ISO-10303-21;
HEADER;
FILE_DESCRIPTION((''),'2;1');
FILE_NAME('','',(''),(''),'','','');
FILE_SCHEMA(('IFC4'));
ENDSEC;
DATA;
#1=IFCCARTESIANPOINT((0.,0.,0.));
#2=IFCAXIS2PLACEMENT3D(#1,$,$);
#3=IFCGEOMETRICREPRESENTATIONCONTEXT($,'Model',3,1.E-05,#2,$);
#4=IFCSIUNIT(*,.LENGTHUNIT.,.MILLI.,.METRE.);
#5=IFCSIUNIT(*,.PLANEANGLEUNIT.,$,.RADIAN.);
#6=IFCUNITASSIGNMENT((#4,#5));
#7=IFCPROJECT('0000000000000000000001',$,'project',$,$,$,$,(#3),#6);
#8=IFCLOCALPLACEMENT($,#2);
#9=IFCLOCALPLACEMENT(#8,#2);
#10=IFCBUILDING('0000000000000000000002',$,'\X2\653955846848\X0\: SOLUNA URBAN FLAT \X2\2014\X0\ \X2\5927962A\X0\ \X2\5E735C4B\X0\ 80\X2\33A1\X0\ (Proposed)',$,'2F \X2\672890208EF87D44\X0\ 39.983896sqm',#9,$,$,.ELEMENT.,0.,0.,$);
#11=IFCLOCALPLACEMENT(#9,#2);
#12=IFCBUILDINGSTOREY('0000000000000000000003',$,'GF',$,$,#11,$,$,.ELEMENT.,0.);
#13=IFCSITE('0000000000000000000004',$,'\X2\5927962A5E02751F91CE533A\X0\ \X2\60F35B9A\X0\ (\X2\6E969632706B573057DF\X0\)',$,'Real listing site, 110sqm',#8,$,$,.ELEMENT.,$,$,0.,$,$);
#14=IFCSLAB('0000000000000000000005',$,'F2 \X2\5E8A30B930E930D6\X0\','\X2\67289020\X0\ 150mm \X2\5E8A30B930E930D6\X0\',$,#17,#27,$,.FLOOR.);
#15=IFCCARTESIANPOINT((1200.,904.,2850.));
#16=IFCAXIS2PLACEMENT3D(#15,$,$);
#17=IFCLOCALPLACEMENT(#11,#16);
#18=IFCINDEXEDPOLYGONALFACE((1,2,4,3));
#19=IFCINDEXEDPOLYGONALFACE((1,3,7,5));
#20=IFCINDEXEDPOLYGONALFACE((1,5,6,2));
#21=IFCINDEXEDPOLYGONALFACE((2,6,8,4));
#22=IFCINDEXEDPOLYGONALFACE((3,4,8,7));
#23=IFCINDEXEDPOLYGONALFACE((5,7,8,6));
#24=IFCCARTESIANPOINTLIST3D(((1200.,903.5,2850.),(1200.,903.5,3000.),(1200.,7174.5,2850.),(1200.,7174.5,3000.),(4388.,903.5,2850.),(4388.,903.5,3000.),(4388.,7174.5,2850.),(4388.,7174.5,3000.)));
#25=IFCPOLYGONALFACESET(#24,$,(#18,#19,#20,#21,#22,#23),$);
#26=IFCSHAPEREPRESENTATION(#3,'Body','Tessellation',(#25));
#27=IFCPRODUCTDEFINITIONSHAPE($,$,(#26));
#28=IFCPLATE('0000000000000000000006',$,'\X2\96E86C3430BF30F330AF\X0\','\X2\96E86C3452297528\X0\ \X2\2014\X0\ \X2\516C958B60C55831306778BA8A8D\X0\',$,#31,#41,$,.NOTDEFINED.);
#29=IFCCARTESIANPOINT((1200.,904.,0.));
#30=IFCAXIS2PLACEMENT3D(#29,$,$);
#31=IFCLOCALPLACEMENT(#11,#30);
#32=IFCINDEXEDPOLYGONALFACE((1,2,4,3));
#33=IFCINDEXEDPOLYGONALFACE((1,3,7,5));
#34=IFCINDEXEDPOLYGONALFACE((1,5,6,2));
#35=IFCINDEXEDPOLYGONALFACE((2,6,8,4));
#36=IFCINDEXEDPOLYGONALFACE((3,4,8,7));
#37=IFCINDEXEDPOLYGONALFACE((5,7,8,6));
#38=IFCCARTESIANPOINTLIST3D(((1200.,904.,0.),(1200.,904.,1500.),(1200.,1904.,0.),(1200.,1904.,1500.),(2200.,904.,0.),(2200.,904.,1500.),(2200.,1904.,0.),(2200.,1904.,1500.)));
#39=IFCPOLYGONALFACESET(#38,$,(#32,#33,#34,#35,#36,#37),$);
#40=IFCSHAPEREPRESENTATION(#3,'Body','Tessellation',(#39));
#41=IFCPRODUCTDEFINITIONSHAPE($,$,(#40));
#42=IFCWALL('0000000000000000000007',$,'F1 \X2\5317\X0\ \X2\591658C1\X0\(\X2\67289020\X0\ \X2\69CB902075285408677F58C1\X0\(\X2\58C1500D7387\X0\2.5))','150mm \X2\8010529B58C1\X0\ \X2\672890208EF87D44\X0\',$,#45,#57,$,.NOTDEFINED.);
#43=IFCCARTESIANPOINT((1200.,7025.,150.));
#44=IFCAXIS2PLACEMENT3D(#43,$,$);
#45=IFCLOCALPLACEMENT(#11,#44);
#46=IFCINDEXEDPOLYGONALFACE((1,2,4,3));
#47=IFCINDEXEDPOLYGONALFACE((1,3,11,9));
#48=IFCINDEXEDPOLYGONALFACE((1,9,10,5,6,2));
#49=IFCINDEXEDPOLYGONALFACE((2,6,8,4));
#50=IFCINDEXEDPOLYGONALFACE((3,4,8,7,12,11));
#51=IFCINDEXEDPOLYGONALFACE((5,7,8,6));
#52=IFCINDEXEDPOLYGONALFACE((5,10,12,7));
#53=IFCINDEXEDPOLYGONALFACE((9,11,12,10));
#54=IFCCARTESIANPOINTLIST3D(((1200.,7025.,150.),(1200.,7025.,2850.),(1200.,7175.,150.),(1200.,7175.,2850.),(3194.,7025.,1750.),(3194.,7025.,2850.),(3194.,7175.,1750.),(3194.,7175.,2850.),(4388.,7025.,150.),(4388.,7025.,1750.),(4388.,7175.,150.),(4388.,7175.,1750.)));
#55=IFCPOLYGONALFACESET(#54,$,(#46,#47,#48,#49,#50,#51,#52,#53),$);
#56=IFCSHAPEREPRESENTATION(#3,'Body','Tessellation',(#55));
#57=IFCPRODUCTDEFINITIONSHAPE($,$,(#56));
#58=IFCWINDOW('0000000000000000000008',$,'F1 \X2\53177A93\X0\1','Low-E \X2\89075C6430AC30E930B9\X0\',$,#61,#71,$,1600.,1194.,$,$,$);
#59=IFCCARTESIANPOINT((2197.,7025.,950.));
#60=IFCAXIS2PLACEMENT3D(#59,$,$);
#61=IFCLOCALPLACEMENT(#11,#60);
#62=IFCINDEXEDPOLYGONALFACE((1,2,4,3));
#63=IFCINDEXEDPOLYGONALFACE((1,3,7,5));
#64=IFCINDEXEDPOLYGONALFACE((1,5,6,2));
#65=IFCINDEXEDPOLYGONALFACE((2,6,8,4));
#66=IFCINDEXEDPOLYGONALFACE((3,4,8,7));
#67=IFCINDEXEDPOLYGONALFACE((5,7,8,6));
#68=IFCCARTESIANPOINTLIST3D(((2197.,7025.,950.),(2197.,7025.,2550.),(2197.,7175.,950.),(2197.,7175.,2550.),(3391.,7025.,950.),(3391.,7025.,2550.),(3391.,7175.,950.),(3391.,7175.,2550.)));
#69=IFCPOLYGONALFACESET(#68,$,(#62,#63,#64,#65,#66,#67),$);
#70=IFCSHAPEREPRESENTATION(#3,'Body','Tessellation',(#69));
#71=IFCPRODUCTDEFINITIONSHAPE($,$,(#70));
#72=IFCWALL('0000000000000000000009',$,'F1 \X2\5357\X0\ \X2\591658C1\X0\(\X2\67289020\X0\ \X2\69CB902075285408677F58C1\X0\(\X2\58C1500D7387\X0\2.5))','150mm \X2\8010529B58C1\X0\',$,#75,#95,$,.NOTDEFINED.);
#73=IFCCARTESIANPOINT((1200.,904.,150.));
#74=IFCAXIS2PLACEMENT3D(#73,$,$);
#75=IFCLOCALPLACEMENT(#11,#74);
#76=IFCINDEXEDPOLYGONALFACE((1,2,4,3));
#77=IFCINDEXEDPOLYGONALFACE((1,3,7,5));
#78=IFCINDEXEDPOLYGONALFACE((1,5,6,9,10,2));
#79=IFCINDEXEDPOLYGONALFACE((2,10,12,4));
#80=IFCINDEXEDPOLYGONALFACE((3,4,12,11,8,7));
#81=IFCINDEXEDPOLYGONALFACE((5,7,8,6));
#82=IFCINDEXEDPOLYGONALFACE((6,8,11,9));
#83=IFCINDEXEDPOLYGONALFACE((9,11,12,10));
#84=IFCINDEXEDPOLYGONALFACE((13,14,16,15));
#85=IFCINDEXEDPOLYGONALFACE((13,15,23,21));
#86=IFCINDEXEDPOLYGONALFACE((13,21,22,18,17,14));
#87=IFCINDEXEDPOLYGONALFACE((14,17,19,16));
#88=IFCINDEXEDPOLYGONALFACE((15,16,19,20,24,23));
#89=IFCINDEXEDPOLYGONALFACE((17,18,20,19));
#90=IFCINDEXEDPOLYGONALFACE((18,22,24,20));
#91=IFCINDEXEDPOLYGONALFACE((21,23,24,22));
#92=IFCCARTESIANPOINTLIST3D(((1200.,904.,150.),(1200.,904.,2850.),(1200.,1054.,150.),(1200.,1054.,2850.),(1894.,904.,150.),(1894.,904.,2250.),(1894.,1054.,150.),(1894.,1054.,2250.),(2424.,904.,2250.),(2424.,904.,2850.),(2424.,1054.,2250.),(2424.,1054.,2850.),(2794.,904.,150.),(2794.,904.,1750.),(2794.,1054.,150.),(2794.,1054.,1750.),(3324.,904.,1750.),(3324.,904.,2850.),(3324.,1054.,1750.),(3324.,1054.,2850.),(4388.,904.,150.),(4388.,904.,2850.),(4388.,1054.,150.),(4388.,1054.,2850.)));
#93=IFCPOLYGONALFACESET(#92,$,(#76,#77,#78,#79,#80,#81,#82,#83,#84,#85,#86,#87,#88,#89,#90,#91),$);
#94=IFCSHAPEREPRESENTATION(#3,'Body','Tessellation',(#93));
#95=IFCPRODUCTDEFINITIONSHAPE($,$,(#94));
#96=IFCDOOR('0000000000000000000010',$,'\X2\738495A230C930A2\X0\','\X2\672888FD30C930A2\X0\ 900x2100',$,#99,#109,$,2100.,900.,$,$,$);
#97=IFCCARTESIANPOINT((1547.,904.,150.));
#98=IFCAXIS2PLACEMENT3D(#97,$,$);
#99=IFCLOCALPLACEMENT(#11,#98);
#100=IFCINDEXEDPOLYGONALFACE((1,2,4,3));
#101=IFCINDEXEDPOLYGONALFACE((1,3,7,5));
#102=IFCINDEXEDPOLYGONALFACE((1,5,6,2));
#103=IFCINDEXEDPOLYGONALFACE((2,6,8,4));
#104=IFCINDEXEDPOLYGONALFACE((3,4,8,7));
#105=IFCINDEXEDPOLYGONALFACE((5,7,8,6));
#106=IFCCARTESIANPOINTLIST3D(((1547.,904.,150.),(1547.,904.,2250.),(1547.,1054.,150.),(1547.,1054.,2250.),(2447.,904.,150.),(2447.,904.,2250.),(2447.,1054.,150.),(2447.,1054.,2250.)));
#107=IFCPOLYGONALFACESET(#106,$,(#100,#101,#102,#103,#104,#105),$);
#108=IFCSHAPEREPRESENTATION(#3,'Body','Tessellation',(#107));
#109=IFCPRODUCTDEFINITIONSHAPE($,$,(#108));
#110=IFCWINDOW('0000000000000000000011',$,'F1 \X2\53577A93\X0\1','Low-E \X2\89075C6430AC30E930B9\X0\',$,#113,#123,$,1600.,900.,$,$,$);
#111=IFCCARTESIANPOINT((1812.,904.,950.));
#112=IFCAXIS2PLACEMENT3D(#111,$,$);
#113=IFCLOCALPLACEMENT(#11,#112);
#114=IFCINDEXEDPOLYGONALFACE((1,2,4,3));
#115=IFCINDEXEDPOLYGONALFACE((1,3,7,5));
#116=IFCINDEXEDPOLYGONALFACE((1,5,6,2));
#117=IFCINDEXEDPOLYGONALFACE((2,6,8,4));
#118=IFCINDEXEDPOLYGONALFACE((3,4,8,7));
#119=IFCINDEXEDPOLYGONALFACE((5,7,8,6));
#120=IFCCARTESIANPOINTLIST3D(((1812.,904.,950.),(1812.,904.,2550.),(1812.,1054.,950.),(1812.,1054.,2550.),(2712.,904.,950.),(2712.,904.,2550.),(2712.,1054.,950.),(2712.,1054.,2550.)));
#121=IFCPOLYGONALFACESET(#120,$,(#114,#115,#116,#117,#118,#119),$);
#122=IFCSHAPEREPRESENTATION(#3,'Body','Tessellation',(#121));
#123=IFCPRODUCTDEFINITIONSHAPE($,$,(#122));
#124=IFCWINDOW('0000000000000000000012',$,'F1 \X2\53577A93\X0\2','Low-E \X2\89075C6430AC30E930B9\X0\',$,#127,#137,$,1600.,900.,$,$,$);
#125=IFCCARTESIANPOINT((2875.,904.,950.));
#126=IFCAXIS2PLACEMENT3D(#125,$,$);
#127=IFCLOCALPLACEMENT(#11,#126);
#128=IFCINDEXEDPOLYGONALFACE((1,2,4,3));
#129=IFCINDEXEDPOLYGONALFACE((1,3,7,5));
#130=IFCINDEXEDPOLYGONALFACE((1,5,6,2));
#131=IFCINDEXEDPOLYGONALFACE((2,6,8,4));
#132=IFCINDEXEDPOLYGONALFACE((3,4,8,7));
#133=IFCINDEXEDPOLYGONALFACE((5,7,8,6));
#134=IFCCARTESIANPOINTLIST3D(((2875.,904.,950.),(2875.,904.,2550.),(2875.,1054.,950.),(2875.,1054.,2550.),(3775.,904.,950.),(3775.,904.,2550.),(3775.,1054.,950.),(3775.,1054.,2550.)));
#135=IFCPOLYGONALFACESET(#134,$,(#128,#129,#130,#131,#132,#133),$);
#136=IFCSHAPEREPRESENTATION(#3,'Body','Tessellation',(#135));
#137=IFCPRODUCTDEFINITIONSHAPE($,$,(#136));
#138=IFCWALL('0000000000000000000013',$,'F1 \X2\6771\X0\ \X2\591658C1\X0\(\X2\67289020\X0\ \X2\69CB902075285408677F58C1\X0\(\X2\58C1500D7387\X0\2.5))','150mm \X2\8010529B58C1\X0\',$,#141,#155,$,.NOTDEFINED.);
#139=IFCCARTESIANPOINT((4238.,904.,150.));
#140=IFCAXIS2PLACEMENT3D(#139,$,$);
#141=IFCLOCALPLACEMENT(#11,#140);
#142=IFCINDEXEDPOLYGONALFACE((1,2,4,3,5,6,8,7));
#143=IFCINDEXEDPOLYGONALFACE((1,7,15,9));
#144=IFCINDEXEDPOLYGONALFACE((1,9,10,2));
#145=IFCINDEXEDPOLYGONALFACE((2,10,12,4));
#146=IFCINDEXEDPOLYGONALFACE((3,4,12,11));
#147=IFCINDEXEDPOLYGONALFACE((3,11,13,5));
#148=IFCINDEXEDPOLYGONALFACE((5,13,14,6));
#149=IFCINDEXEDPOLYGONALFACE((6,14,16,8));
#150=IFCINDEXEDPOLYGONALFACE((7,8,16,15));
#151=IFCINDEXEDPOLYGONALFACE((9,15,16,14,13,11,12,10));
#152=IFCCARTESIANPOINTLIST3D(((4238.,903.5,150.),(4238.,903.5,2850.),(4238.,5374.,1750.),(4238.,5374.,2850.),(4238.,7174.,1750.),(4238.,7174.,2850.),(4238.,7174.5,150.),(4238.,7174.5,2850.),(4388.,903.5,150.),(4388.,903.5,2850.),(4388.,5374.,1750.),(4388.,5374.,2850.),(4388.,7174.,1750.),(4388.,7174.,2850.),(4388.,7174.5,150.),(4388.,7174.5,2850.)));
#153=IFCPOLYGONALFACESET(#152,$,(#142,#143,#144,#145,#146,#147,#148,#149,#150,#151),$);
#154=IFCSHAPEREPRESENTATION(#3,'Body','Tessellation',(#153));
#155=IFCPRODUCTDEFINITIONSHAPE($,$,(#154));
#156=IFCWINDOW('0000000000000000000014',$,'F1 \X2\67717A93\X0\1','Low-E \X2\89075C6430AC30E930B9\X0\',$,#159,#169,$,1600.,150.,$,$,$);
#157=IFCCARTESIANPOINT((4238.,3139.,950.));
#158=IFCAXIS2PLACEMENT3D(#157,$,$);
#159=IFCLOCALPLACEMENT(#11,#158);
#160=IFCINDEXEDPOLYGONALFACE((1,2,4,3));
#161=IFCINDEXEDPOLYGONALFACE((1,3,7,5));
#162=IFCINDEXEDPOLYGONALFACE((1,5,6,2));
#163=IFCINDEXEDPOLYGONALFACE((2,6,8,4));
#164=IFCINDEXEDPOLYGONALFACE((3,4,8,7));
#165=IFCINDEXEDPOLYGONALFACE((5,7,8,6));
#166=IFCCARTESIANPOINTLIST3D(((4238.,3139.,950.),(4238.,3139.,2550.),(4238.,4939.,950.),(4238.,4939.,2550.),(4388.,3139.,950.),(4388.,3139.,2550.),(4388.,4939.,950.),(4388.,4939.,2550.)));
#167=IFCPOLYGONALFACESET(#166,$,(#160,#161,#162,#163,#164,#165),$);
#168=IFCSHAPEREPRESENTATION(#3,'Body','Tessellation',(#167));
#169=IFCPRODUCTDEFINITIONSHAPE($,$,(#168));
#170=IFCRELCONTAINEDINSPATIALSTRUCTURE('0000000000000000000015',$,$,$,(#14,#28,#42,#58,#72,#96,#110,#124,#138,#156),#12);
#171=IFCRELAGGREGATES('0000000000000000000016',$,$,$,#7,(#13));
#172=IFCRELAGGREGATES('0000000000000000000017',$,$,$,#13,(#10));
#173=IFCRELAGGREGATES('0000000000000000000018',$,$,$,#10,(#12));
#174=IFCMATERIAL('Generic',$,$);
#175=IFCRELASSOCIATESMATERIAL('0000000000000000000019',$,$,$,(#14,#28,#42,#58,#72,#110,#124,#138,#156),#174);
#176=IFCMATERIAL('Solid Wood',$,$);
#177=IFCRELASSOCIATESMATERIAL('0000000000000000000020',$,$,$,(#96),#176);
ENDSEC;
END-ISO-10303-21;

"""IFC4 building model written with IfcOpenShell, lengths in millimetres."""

from ifc_helpers import new_model, si_unit, frame, frame_2d, origin, place, context, project, spatial, rectangle, extrude, material, element, fill, save


model = new_model("IFC4")

# Units and contexts
model_context = context("Model", 3, precision=1e-05, world=origin())
ifc_project = project(units=[si_unit("LENGTHUNIT", "METRE", prefix="MILLI"), si_unit("PLANEANGLEUNIT", "RADIAN")], contexts=[model_context])

# Site, building, storey
site_placement = place(None, origin())
site = spatial("IfcSite", under=ifc_project, at=site_placement, Name="大阪市生野区 想定 (準防火地域)", ObjectType="Real listing site, 110sqm", CompositionType="ELEMENT", RefElevation=0.0)
building_placement = place(site_placement, origin())
building = spatial("IfcBuilding", under=site, at=building_placement, Name="改善案: SOLUNA URBAN FLAT — 大阪 平屋 80㎡ (Proposed)", ObjectType="2F 木造軸組 39.983896sqm", CompositionType="ELEMENT", ElevationOfRefHeight=0.0, ElevationOfTerrain=0.0)
storey_placement = place(building_placement, origin())
storey = spatial("IfcBuildingStorey", under=building, at=storey_placement, Name="GF", CompositionType="ELEMENT", Elevation=0.0)

# Slab
ifc_material_1 = material(Name="Generic")
slab_1_placement = place(storey_placement, frame((1200.0, 904.0, 2850.0)))
element("IfcSlab", 1, at=slab_1_placement, inside=storey, material=ifc_material_1, Name="F2 床スラブ", Description="木造 150mm 床スラブ", PredefinedType="FLOOR", context=model_context, shape_type="SweptSolid", body=[
    extrude(rectangle(XDim=3188.0, YDim=6271.0, at=frame_2d((1594.0, 3135.0))), frame((1200.0, 904.0, 2850.0)), (0.0, 0.0, 1.0), 150.0),
])

# Plate
plate_placement = place(storey_placement, frame((1200.0, 904.0, 0.0)))
element("IfcPlate", 2, at=plate_placement, inside=storey, material=ifc_material_1, Name="雨水タンク", Description="雨水利用 — 公開情報で確認", PredefinedType="NOTDEFINED", context=model_context, shape_type="SweptSolid", body=[
    extrude(rectangle(XDim=1000.0, YDim=1000.0, at=frame_2d((500.0, 500.0))), frame((1200.0, 904.0, 0.0)), (0.0, 0.0, 1.0), 1500.0),
])

# Wall, opening, window
wall_1_placement = place(storey_placement, frame((1200.0, 7025.0, 150.0)))
wall_1 = element("IfcWall", 3, at=wall_1_placement, inside=storey, material=ifc_material_1, Name="F1 北 外壁(木造 構造用合板壁(壁倍率2.5))", Description="150mm 耐力壁 木造軸組", PredefinedType="NOTDEFINED", context=model_context, shape_type="SweptSolid", body=[
    extrude(rectangle(XDim=3188.0, YDim=150.0, at=frame_2d((1594.0, 75.0))), frame((1200.0, 7025.0, 150.0)), (0.0, 0.0, 1.0), 2700.0),
])
opening_1_placement = place(storey_placement, frame((2197.0, 7025.0, 950.0)))
opening_1 = element("IfcOpeningElement", 4, at=opening_1_placement, cuts=wall_1, PredefinedType="NOTDEFINED", context=model_context, shape_type="SweptSolid", body=[
    extrude(rectangle(XDim=1194.0, YDim=150.0, at=frame_2d((597.0, 75.0))), frame((2197.0, 7025.0, 950.0)), (0.0, 0.0, 1.0), 1600.0),
])
window_1_placement = place(storey_placement, frame((2197.0, 7025.0, 950.0)))
window_1 = element("IfcWindow", 5, at=window_1_placement, inside=storey, material=ifc_material_1, Name="F1 北窓1", Description="Low-E 複層ガラス", OverallHeight=1600.0, OverallWidth=1194.0, context=model_context, shape_type="SweptSolid", body=[
    extrude(rectangle(XDim=1194.0, YDim=150.0, at=frame_2d((597.0, 75.0))), frame((2197.0, 7025.0, 950.0)), (0.0, 0.0, 1.0), 1600.0),
])
fill(opening_1, window_1)

# Wall, openings, door, windows
wall_2_placement = place(storey_placement, frame((1200.0, 904.0, 150.0)))
wall_2 = element("IfcWall", 6, at=wall_2_placement, inside=storey, material=ifc_material_1, Name="F1 南 外壁(木造 構造用合板壁(壁倍率2.5))", Description="150mm 耐力壁", PredefinedType="NOTDEFINED", context=model_context, shape_type="SweptSolid", body=[
    extrude(rectangle(XDim=3188.0, YDim=150.0, at=frame_2d((1594.0, 75.0))), frame((1200.0, 904.0, 150.0)), (0.0, 0.0, 1.0), 2700.0),
])
opening_2_placement = place(storey_placement, frame((1547.0, 904.0, 150.0)))
opening_2 = element("IfcOpeningElement", 7, at=opening_2_placement, cuts=wall_2, PredefinedType="NOTDEFINED", context=model_context, shape_type="SweptSolid", body=[
    extrude(rectangle(XDim=900.0, YDim=150.0, at=frame_2d((450.0, 75.0))), frame((1547.0, 904.0, 150.0)), (0.0, 0.0, 1.0), 2100.0),
])
opening_3_placement = place(storey_placement, frame((1812.0, 904.0, 950.0)))
opening_3 = element("IfcOpeningElement", 8, at=opening_3_placement, cuts=wall_2, PredefinedType="NOTDEFINED", context=model_context, shape_type="SweptSolid", body=[
    extrude(rectangle(XDim=900.0, YDim=150.0, at=frame_2d((450.0, 75.0))), frame((1812.0, 904.0, 950.0)), (0.0, 0.0, 1.0), 1600.0),
])
opening_4_placement = place(storey_placement, frame((2875.0, 904.0, 950.0)))
opening_4 = element("IfcOpeningElement", 9, at=opening_4_placement, cuts=wall_2, PredefinedType="NOTDEFINED", context=model_context, shape_type="SweptSolid", body=[
    extrude(rectangle(XDim=900.0, YDim=150.0, at=frame_2d((450.0, 75.0))), frame((2875.0, 904.0, 950.0)), (0.0, 0.0, 1.0), 1600.0),
])
ifc_material_2 = material(Name="Solid Wood")
door_placement = place(storey_placement, frame((1547.0, 904.0, 150.0)))
door = element("IfcDoor", 10, at=door_placement, inside=storey, material=ifc_material_2, Name="玄関ドア", Description="木製ドア 900x2100", OverallHeight=2100.0, OverallWidth=900.0, context=model_context, shape_type="SweptSolid", body=[
    extrude(rectangle(XDim=900.0, YDim=150.0, at=frame_2d((450.0, 75.0))), frame((1547.0, 904.0, 150.0)), (0.0, 0.0, 1.0), 2100.0),
])
fill(opening_2, door)
window_2_placement = place(storey_placement, frame((1812.0, 904.0, 950.0)))
window_2 = element("IfcWindow", 11, at=window_2_placement, inside=storey, material=ifc_material_1, Name="F1 南窓1", Description="Low-E 複層ガラス", OverallHeight=1600.0, OverallWidth=900.0, context=model_context, shape_type="SweptSolid", body=[
    extrude(rectangle(XDim=900.0, YDim=150.0, at=frame_2d((450.0, 75.0))), frame((1812.0, 904.0, 950.0)), (0.0, 0.0, 1.0), 1600.0),
])
fill(opening_3, window_2)
window_3_placement = place(storey_placement, frame((2875.0, 904.0, 950.0)))
window_3 = element("IfcWindow", 12, at=window_3_placement, inside=storey, material=ifc_material_1, Name="F1 南窓2", Description="Low-E 複層ガラス", OverallHeight=1600.0, OverallWidth=900.0, context=model_context, shape_type="SweptSolid", body=[
    extrude(rectangle(XDim=900.0, YDim=150.0, at=frame_2d((450.0, 75.0))), frame((2875.0, 904.0, 950.0)), (0.0, 0.0, 1.0), 1600.0),
])
fill(opening_4, window_3)

# Wall, opening, window
wall_3_placement = place(storey_placement, frame((4238.0, 904.0, 150.0)))
wall_3 = element("IfcWall", 13, at=wall_3_placement, inside=storey, material=ifc_material_1, Name="F1 東 外壁(木造 構造用合板壁(壁倍率2.5))", Description="150mm 耐力壁", PredefinedType="NOTDEFINED", context=model_context, shape_type="SweptSolid", body=[
    extrude(rectangle(XDim=150.0, YDim=6271.0, at=frame_2d((75.0, 3135.0))), frame((4238.0, 904.0, 150.0)), (0.0, 0.0, 1.0), 2700.0),
])
opening_5_placement = place(storey_placement, frame((4238.0, 3139.0, 950.0)))
opening_5 = element("IfcOpeningElement", 14, at=opening_5_placement, cuts=wall_3, PredefinedType="NOTDEFINED", context=model_context, shape_type="SweptSolid", body=[
    extrude(rectangle(XDim=150.0, YDim=1800.0, at=frame_2d((75.0, 900.0))), frame((4238.0, 3139.0, 950.0)), (0.0, 0.0, 1.0), 1600.0),
])
window_4_placement = place(storey_placement, frame((4238.0, 3139.0, 950.0)))
window_4 = element("IfcWindow", 15, at=window_4_placement, inside=storey, material=ifc_material_1, Name="F1 東窓1", Description="Low-E 複層ガラス", OverallHeight=1600.0, OverallWidth=150.0, context=model_context, shape_type="SweptSolid", body=[
    extrude(rectangle(XDim=150.0, YDim=1800.0, at=frame_2d((75.0, 900.0))), frame((4238.0, 3139.0, 950.0)), (0.0, 0.0, 1.0), 1600.0),
])
fill(opening_5, window_4)

save(model, "model.ifc")
